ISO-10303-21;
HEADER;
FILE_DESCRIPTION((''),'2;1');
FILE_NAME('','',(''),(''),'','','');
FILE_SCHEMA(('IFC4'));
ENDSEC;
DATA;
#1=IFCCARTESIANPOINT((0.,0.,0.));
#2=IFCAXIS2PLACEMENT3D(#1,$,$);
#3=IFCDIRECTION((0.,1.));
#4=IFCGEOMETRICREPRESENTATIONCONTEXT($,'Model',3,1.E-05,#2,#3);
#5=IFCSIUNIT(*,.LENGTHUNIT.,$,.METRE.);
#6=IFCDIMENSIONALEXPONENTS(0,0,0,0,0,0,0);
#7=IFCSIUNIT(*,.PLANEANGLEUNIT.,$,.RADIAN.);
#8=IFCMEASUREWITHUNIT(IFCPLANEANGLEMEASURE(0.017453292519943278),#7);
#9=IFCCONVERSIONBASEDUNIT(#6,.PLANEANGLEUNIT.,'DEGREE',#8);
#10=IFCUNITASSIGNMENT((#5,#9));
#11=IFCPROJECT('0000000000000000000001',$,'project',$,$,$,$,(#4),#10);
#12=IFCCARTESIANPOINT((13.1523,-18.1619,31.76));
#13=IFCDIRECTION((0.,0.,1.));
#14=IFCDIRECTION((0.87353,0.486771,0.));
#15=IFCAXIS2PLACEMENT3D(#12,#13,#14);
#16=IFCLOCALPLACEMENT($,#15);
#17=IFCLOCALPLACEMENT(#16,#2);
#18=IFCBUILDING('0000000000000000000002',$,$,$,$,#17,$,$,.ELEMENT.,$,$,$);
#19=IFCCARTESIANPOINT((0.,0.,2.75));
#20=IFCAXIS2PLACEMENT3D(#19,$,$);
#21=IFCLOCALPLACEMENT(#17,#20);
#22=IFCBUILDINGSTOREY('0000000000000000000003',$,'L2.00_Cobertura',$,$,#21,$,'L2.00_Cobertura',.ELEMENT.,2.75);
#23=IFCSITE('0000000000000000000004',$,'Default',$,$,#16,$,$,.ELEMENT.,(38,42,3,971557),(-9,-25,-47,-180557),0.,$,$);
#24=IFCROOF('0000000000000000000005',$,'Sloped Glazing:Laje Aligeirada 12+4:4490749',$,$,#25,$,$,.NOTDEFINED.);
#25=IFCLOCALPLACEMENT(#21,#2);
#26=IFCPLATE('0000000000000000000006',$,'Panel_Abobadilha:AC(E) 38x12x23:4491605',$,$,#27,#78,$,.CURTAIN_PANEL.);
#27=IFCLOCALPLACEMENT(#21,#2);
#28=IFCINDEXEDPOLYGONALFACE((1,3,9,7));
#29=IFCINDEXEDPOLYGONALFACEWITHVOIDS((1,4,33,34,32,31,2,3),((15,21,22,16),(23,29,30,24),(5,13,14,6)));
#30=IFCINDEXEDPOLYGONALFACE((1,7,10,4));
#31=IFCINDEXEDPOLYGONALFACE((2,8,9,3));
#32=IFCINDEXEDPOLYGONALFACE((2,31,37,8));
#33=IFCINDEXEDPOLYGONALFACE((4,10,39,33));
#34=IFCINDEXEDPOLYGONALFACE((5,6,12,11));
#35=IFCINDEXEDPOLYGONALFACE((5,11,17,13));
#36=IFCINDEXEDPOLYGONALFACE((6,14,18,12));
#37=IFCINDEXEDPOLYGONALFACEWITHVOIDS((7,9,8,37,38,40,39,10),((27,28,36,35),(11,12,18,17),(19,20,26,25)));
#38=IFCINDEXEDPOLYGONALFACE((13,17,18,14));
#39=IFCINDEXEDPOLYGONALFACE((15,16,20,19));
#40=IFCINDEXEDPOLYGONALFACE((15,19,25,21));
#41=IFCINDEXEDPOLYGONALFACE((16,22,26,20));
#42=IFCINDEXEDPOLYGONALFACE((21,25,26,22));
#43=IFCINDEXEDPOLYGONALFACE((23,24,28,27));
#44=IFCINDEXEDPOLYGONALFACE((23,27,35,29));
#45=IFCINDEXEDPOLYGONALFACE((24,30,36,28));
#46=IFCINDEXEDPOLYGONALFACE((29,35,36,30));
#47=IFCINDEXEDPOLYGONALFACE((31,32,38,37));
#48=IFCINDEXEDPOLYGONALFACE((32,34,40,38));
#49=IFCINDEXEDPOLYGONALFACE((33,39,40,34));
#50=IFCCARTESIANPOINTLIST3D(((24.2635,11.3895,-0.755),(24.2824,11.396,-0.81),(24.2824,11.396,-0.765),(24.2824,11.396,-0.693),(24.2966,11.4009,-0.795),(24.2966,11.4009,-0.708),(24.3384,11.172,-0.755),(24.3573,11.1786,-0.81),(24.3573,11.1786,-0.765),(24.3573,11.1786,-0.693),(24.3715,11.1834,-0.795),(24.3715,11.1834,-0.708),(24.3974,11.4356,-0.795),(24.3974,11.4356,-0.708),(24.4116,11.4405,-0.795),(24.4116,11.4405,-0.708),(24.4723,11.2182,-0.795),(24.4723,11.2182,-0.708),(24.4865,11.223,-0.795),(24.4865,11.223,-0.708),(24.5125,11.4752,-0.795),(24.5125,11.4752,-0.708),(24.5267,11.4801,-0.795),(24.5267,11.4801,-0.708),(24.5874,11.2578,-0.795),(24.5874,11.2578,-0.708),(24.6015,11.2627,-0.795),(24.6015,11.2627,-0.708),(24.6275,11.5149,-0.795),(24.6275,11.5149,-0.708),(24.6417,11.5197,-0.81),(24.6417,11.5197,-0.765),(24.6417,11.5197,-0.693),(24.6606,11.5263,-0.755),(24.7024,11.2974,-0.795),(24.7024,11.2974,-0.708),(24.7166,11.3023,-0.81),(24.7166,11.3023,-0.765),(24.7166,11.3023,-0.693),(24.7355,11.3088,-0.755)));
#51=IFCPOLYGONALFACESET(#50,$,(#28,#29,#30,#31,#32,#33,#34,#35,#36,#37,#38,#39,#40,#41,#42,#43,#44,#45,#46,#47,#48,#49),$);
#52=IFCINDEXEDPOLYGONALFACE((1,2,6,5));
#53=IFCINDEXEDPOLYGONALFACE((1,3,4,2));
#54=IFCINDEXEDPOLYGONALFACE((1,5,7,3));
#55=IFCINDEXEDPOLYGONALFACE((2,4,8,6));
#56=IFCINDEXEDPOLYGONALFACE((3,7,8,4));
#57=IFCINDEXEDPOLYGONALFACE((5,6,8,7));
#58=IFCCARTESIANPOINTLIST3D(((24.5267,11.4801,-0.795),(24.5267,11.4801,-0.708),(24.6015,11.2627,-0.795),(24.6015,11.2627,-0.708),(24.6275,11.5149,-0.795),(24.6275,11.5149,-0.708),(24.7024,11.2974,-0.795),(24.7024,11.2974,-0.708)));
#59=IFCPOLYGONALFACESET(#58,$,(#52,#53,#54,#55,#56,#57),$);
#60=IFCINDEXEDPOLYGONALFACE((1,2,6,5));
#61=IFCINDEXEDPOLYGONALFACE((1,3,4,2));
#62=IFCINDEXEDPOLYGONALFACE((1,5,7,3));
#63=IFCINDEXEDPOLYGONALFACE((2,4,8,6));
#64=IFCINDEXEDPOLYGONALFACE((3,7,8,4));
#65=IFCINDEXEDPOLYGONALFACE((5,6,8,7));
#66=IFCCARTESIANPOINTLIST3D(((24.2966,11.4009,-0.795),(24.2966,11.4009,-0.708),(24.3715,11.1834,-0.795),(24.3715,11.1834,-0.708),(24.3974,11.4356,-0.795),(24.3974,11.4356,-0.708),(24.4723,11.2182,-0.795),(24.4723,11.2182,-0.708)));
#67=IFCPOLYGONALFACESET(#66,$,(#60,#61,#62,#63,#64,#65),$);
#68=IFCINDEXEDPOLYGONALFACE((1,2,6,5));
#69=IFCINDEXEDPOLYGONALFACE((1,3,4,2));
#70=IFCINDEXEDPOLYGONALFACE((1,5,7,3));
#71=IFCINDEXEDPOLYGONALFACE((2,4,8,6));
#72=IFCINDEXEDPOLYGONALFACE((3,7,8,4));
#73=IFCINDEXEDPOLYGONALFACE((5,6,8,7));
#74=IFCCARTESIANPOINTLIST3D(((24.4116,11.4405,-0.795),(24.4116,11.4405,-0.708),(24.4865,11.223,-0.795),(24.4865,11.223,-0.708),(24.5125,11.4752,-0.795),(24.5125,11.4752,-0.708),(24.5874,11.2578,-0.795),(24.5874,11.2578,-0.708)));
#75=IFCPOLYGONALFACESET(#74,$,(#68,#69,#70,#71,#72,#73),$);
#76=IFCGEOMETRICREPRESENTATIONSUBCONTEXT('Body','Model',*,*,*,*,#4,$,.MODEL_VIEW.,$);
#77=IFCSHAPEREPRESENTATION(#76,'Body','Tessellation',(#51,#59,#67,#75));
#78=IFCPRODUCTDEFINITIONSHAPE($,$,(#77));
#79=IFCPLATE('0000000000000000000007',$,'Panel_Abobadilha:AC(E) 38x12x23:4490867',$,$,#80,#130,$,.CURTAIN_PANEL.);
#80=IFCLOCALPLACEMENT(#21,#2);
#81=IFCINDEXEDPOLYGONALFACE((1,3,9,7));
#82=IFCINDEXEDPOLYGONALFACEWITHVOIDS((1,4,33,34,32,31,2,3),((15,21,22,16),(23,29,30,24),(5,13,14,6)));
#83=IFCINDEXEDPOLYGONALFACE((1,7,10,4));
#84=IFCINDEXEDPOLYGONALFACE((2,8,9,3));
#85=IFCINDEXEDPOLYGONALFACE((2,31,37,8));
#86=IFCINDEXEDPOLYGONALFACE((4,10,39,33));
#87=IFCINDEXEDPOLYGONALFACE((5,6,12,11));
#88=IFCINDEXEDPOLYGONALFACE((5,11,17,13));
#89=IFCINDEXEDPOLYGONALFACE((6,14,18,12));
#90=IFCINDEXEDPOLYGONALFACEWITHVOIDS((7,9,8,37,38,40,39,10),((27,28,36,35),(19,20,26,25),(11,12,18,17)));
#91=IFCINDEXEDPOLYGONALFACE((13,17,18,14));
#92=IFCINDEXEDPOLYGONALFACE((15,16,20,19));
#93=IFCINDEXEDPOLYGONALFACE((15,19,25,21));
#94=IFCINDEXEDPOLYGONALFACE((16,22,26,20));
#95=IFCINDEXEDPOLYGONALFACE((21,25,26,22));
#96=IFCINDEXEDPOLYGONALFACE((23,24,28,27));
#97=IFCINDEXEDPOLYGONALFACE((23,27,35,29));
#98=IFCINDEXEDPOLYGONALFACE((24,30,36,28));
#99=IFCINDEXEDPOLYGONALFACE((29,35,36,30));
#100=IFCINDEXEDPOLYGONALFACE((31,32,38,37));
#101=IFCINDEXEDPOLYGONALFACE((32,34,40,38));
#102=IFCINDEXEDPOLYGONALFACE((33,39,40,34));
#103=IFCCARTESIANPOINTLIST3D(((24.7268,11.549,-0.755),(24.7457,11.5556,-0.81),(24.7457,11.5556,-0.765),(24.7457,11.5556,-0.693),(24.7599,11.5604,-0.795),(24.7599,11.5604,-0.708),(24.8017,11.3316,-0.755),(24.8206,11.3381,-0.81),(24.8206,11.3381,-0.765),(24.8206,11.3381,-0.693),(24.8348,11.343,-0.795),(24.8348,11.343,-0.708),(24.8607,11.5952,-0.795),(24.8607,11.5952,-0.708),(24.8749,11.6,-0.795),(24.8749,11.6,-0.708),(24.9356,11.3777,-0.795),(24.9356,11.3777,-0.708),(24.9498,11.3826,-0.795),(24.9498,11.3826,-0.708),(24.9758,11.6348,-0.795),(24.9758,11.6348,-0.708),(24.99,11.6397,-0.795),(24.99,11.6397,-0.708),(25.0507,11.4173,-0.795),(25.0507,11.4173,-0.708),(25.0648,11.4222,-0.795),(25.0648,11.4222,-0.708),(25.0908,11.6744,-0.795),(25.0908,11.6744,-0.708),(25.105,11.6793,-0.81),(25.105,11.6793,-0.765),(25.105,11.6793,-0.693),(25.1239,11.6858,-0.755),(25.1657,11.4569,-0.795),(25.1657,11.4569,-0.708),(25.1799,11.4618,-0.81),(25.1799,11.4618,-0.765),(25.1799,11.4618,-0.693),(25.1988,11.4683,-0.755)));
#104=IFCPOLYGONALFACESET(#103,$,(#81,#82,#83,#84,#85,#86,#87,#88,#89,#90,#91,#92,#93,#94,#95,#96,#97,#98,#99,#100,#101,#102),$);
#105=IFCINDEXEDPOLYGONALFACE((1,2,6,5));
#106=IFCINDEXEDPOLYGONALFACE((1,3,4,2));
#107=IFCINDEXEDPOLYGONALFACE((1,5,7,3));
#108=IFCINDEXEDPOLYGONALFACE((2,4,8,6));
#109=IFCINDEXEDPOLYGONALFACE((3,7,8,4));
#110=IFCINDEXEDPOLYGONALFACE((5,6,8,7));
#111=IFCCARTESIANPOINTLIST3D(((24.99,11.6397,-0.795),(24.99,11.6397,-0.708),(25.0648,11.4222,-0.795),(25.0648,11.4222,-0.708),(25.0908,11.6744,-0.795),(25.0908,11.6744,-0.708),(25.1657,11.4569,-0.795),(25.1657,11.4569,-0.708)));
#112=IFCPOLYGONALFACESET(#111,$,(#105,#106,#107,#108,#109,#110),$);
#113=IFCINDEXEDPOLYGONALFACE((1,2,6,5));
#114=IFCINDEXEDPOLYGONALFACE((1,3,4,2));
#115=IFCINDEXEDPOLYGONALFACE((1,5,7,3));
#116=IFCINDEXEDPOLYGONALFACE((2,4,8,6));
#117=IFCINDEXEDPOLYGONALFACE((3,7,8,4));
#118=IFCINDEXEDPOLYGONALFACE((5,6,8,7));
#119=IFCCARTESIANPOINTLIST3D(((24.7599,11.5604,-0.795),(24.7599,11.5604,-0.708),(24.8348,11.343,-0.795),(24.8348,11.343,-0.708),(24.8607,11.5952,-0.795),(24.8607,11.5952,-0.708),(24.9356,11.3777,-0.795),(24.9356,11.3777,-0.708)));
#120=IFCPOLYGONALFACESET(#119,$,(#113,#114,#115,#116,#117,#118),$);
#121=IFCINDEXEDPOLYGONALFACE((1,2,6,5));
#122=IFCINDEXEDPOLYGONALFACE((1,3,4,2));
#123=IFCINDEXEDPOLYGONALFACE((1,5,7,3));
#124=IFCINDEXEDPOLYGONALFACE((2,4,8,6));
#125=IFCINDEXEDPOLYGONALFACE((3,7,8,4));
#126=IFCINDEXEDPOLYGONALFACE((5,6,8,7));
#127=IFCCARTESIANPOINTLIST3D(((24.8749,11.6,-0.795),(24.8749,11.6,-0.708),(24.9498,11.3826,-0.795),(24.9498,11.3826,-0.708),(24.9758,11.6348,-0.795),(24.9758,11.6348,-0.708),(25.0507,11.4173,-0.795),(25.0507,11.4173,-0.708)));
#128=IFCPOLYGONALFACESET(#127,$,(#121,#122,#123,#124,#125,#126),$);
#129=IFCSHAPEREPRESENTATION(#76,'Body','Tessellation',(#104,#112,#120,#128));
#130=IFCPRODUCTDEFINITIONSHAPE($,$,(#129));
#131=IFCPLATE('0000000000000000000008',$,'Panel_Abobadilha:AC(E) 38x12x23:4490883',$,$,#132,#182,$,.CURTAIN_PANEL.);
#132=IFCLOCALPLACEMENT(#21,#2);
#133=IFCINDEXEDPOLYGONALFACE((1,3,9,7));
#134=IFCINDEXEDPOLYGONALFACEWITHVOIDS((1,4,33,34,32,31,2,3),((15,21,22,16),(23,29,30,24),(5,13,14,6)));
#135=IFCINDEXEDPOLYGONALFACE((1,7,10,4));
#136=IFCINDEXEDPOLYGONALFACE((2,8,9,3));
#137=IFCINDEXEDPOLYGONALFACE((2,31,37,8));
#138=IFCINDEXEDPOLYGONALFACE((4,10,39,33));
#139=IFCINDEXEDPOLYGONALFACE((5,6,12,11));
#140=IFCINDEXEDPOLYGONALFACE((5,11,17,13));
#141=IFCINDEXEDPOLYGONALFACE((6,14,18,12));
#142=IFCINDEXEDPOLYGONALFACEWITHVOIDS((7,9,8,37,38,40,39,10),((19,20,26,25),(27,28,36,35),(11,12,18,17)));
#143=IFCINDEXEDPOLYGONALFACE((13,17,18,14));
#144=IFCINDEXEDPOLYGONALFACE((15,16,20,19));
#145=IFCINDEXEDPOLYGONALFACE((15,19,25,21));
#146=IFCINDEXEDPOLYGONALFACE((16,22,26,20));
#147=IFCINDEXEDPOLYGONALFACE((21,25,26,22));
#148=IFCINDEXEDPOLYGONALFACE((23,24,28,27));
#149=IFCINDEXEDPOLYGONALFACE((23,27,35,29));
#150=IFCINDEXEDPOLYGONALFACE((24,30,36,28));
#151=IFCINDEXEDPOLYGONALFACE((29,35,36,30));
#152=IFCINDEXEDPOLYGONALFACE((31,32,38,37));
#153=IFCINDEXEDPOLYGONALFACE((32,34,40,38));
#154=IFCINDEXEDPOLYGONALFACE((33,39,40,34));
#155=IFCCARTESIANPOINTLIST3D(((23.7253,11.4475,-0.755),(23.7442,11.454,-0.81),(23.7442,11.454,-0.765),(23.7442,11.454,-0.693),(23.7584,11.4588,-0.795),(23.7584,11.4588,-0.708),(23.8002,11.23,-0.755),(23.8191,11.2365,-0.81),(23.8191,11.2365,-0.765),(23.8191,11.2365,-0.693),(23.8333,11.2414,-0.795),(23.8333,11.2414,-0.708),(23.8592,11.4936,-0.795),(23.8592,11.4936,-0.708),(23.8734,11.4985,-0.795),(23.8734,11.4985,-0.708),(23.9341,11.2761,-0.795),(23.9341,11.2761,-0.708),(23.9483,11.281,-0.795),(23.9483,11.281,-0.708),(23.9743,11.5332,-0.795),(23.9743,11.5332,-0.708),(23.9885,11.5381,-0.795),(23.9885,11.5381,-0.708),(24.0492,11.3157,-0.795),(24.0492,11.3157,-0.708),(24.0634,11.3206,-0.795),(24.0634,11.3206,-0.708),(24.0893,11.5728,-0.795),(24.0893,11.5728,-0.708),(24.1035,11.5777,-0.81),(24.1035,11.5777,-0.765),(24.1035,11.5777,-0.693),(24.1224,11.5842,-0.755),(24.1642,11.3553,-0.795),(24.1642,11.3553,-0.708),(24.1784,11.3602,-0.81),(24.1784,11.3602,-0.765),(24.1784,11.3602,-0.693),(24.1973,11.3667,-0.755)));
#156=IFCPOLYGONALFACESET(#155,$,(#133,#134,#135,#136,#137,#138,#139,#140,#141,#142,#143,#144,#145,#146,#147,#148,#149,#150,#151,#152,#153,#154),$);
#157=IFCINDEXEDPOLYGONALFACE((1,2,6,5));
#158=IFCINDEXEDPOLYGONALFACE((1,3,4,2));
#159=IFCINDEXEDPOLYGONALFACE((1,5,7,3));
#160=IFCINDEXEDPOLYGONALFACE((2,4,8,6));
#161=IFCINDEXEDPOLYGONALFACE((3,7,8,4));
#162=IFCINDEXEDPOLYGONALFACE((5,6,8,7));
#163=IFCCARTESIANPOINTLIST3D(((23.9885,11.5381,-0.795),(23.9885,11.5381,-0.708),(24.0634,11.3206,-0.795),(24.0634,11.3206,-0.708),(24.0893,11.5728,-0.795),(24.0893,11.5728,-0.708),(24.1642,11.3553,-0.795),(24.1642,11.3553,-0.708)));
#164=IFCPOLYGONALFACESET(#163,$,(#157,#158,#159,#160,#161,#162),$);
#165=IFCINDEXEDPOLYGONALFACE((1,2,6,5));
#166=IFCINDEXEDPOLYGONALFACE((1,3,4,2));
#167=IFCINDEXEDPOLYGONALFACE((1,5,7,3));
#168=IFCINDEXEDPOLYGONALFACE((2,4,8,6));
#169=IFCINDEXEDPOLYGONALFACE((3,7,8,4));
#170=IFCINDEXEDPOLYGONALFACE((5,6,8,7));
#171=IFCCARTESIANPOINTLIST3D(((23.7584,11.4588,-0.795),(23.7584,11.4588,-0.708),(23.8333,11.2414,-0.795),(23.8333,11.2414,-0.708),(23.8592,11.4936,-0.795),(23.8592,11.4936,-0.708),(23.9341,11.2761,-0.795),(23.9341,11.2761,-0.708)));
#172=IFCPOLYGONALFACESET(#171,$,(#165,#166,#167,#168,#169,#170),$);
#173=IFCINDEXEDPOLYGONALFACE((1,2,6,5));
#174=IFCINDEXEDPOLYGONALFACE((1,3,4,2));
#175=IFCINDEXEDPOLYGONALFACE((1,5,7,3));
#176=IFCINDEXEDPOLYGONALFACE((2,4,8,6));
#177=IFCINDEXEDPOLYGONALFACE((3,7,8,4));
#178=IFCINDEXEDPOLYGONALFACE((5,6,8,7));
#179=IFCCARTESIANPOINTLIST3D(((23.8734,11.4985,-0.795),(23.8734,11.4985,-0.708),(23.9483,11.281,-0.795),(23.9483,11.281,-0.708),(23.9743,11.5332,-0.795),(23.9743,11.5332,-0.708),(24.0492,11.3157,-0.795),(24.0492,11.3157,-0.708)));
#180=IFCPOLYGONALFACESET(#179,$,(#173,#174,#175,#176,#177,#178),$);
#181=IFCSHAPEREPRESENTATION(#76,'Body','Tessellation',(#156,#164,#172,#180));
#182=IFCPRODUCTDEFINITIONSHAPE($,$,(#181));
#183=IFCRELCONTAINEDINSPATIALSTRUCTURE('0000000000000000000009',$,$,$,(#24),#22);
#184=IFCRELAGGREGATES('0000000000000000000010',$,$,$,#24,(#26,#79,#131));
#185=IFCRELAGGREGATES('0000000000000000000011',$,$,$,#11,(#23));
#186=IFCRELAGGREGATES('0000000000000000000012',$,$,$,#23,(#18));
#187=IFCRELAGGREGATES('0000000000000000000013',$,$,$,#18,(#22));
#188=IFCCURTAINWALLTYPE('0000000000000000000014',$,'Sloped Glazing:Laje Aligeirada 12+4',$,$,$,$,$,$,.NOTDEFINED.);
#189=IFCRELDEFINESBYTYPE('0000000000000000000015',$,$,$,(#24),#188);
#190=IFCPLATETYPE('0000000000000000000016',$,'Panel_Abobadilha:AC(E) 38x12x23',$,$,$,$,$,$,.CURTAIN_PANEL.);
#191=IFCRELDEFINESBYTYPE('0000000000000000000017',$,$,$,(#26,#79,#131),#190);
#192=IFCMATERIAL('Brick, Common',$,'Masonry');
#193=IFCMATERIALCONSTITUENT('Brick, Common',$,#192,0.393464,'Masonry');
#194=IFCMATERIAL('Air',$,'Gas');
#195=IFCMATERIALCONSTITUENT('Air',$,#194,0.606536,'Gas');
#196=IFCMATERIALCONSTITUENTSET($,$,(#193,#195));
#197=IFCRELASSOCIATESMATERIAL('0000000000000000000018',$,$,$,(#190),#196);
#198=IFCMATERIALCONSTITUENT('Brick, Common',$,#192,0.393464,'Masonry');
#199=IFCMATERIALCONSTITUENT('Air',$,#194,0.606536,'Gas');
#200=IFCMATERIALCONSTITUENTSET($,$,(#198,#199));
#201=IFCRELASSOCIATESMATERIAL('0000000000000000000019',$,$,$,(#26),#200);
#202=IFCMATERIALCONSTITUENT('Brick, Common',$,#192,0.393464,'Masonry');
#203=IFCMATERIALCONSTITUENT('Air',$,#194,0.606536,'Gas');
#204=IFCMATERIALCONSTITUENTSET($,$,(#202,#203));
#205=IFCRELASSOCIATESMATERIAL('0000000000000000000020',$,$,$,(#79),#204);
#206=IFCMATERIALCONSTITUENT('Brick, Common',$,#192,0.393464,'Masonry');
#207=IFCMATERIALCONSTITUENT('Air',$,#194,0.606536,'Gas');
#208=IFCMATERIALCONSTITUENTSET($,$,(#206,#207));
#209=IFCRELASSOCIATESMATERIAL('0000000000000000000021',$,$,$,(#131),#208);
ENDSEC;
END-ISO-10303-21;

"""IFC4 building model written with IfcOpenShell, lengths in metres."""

from ifc_helpers import new_model, entity, si_unit, converted_unit, direction, frame, origin, place, context, subcontext, project, spatial, indexed_curve, outline, extrude, source, transform, mapped, material, constituent, constituent_set, type_object, type_shapes, element, aggregate, save


model = new_model("IFC4")

# Units and contexts
model_context = context("Model", 3, precision=1e-05, world=origin(), true_north=direction((0.0, 1.0)))
body_context = subcontext(model_context, "Body", "Model", "MODEL_VIEW")
ifc_project = project(units=[si_unit("LENGTHUNIT", "METRE"), converted_unit("PLANEANGLEUNIT", "DEGREE", entity("IfcPlaneAngleMeasure", 0.017453292519943278), si_unit("PLANEANGLEUNIT", "RADIAN"), dimensions=[0, 0, 0, 0, 0, 0, 0])], contexts=[model_context])

# Site, building, storey
site_placement = place(None, frame((13.1523, -18.1619, 31.76), z_axis=(0.0, 0.0, 1.0), x_axis=(0.87353, 0.486771, 0.0)))
site = spatial("IfcSite", under=ifc_project, at=site_placement, Name="Default", CompositionType="ELEMENT", RefLatitude=(38, 42, 3, 971557), RefLongitude=(-9, -25, -47, -180557), RefElevation=0.0)
building_placement = place(site_placement, origin())
building = spatial("IfcBuilding", under=site, at=building_placement, CompositionType="ELEMENT")
storey_placement = place(building_placement, frame((0.0, 0.0, 2.75)))
storey = spatial("IfcBuildingStorey", under=building, at=storey_placement, Name="L2.00_Cobertura", LongName="L2.00_Cobertura", CompositionType="ELEMENT", Elevation=2.75)

# Roof, plates
curtain_wall_type = type_object("IfcCurtainWallType", Name="Sloped Glazing:Laje Aligeirada 12+4", PredefinedType="NOTDEFINED")
roof_placement = place(storey_placement, frame((0.0, 0.0, -2.75)))
roof = element("IfcRoof", 1, at=roof_placement, inside=storey, type_object=curtain_wall_type, Name="Sloped Glazing:Laje Aligeirada 12+4:4490749", PredefinedType="NOTDEFINED")
ifc_material_1 = material(Name="Brick, Common", Category="Masonry")
ifc_material_2 = material(Name="Air", Category="Gas")
ifc_constituent_1 = constituent(ifc_material_1, Name="Brick, Common", Category="Masonry", fraction=0.393464)
ifc_constituent_2 = constituent(ifc_material_2, Name="Air", Category="Gas", fraction=0.606536)
ifc_constituent_set_1 = constituent_set(constituents=[ifc_constituent_1, ifc_constituent_2])
plate_type_1 = type_object("IfcPlateType", Name="Panel_Abobadilha:AC(E) 38x12x23", PredefinedType="CURTAIN_PANEL", material=ifc_constituent_set_1)
shared_shape_1 = source(origin(), body_context, "Body", "SweptSolid", [
    extrude(outline(indexed_curve([(-0.19, -0.0543), (0.19, -0.0543), (0.19, -0.0093), (0.21, 0.0007), (0.19, 0.0628), (-0.19, 0.0628), (-0.21, 0.0007), (-0.19, -0.0093), (-0.19, -0.0543)], self_intersect=False), holes=[indexed_curve([(-0.0683, 0.0477), (-0.0683, -0.0393), (-0.175, -0.0393), (-0.175, 0.0477), (-0.0683, 0.0477)], self_intersect=False), indexed_curve([(0.0533, 0.0477), (0.0533, -0.0393), (-0.0533, -0.0393), (-0.0533, 0.0477), (0.0533, 0.0477)], self_intersect=False), indexed_curve([(0.175, 0.0477), (0.175, -0.0393), (0.0683, -0.0393), (0.0683, 0.0477), (0.175, 0.0477)], self_intersect=False)]), frame((0.0, 0.0543, 0.0)), (0.0, 0.0, 1.0), 0.23),
    extrude(outline(indexed_curve([(-0.0533, -0.0435), (0.0533, -0.0435), (0.0533, 0.0435), (-0.0533, 0.0435), (-0.0533, -0.0435)], self_intersect=False)), frame((0.1217, 0.0585, 0.0), z_axis=(0.0, 0.0, 1.0), x_axis=(-1.0, 0.0, 0.0)), (0.0, 0.0, 1.0), 0.23),
    extrude(outline(indexed_curve([(-0.0533, -0.0435), (0.0533, -0.0435), (0.0533, 0.0435), (-0.0533, 0.0435), (-0.0533, -0.0435)], self_intersect=False)), frame((-0.1217, 0.0585, 0.0), z_axis=(0.0, 0.0, 1.0), x_axis=(-1.0, 0.0, 0.0)), (0.0, 0.0, 1.0), 0.23),
    extrude(outline(indexed_curve([(-0.0533, -0.0435), (0.0533, -0.0435), (0.0533, 0.0435), (-0.0533, 0.0435), (-0.0533, -0.0435)], self_intersect=False)), frame((0.0, 0.0585, 0.0), z_axis=(0.0, 0.0, 1.0), x_axis=(-1.0, 0.0, 0.0)), (0.0, 0.0, 1.0), 0.23),
])
type_shapes(plate_type_1, [shared_shape_1])
ifc_constituent_3 = constituent(ifc_material_1, Name="Brick, Common", Category="Masonry", fraction=0.393464)
ifc_constituent_4 = constituent(ifc_material_2, Name="Air", Category="Gas", fraction=0.606536)
ifc_constituent_set_2 = constituent_set(constituents=[ifc_constituent_3, ifc_constituent_4])
plate_1_placement = place(roof_placement, frame((24.462, 11.4579, 1.94), z_axis=(0.325568, -0.945519, 0.0), x_axis=(0.945519, 0.325568, 0.0)))
plate_1 = element("IfcPlate", 2, at=plate_1_placement, type_object=plate_type_1, material=ifc_constituent_set_2, Name="Panel_Abobadilha:AC(E) 38x12x23:4491605", PredefinedType="CURTAIN_PANEL", context=body_context, shape_type="MappedRepresentation", body=[
    mapped(shared_shape_1, transform((0.0, 0.0, 0.0), scale=1.0)),
])
ifc_constituent_5 = constituent(ifc_material_1, Name="Brick, Common", Category="Masonry", fraction=0.393464)
ifc_constituent_6 = constituent(ifc_material_2, Name="Air", Category="Gas", fraction=0.606536)
ifc_constituent_set_3 = constituent_set(constituents=[ifc_constituent_5, ifc_constituent_6])
plate_2_placement = place(roof_placement, frame((24.9253, 11.6174, 1.94), z_axis=(0.325568, -0.945519, 0.0), x_axis=(0.945519, 0.325568, 0.0)))
plate_2 = element("IfcPlate", 3, at=plate_2_placement, type_object=plate_type_1, material=ifc_constituent_set_3, Name="Panel_Abobadilha:AC(E) 38x12x23:4490867", PredefinedType="CURTAIN_PANEL", context=body_context, shape_type="MappedRepresentation", body=[
    mapped(shared_shape_1, transform((0.0, 0.0, 0.0), scale=1.0)),
])
ifc_constituent_7 = constituent(ifc_material_1, Name="Brick, Common", Category="Masonry", fraction=0.393464)
ifc_constituent_8 = constituent(ifc_material_2, Name="Air", Category="Gas", fraction=0.606536)
ifc_constituent_set_4 = constituent_set(constituents=[ifc_constituent_7, ifc_constituent_8])
plate_3_placement = place(roof_placement, frame((23.9239, 11.5158, 1.94), z_axis=(0.325568, -0.945519, 0.0), x_axis=(0.945519, 0.325568, 0.0)))
plate_3 = element("IfcPlate", 4, at=plate_3_placement, type_object=plate_type_1, material=ifc_constituent_set_4, Name="Panel_Abobadilha:AC(E) 38x12x23:4490883", PredefinedType="CURTAIN_PANEL", context=body_context, shape_type="MappedRepresentation", body=[
    mapped(shared_shape_1, transform((0.0, 0.0, 0.0), scale=1.0)),
])
aggregate(roof, [plate_1, plate_2, plate_3])

save(model, "model.ifc")
